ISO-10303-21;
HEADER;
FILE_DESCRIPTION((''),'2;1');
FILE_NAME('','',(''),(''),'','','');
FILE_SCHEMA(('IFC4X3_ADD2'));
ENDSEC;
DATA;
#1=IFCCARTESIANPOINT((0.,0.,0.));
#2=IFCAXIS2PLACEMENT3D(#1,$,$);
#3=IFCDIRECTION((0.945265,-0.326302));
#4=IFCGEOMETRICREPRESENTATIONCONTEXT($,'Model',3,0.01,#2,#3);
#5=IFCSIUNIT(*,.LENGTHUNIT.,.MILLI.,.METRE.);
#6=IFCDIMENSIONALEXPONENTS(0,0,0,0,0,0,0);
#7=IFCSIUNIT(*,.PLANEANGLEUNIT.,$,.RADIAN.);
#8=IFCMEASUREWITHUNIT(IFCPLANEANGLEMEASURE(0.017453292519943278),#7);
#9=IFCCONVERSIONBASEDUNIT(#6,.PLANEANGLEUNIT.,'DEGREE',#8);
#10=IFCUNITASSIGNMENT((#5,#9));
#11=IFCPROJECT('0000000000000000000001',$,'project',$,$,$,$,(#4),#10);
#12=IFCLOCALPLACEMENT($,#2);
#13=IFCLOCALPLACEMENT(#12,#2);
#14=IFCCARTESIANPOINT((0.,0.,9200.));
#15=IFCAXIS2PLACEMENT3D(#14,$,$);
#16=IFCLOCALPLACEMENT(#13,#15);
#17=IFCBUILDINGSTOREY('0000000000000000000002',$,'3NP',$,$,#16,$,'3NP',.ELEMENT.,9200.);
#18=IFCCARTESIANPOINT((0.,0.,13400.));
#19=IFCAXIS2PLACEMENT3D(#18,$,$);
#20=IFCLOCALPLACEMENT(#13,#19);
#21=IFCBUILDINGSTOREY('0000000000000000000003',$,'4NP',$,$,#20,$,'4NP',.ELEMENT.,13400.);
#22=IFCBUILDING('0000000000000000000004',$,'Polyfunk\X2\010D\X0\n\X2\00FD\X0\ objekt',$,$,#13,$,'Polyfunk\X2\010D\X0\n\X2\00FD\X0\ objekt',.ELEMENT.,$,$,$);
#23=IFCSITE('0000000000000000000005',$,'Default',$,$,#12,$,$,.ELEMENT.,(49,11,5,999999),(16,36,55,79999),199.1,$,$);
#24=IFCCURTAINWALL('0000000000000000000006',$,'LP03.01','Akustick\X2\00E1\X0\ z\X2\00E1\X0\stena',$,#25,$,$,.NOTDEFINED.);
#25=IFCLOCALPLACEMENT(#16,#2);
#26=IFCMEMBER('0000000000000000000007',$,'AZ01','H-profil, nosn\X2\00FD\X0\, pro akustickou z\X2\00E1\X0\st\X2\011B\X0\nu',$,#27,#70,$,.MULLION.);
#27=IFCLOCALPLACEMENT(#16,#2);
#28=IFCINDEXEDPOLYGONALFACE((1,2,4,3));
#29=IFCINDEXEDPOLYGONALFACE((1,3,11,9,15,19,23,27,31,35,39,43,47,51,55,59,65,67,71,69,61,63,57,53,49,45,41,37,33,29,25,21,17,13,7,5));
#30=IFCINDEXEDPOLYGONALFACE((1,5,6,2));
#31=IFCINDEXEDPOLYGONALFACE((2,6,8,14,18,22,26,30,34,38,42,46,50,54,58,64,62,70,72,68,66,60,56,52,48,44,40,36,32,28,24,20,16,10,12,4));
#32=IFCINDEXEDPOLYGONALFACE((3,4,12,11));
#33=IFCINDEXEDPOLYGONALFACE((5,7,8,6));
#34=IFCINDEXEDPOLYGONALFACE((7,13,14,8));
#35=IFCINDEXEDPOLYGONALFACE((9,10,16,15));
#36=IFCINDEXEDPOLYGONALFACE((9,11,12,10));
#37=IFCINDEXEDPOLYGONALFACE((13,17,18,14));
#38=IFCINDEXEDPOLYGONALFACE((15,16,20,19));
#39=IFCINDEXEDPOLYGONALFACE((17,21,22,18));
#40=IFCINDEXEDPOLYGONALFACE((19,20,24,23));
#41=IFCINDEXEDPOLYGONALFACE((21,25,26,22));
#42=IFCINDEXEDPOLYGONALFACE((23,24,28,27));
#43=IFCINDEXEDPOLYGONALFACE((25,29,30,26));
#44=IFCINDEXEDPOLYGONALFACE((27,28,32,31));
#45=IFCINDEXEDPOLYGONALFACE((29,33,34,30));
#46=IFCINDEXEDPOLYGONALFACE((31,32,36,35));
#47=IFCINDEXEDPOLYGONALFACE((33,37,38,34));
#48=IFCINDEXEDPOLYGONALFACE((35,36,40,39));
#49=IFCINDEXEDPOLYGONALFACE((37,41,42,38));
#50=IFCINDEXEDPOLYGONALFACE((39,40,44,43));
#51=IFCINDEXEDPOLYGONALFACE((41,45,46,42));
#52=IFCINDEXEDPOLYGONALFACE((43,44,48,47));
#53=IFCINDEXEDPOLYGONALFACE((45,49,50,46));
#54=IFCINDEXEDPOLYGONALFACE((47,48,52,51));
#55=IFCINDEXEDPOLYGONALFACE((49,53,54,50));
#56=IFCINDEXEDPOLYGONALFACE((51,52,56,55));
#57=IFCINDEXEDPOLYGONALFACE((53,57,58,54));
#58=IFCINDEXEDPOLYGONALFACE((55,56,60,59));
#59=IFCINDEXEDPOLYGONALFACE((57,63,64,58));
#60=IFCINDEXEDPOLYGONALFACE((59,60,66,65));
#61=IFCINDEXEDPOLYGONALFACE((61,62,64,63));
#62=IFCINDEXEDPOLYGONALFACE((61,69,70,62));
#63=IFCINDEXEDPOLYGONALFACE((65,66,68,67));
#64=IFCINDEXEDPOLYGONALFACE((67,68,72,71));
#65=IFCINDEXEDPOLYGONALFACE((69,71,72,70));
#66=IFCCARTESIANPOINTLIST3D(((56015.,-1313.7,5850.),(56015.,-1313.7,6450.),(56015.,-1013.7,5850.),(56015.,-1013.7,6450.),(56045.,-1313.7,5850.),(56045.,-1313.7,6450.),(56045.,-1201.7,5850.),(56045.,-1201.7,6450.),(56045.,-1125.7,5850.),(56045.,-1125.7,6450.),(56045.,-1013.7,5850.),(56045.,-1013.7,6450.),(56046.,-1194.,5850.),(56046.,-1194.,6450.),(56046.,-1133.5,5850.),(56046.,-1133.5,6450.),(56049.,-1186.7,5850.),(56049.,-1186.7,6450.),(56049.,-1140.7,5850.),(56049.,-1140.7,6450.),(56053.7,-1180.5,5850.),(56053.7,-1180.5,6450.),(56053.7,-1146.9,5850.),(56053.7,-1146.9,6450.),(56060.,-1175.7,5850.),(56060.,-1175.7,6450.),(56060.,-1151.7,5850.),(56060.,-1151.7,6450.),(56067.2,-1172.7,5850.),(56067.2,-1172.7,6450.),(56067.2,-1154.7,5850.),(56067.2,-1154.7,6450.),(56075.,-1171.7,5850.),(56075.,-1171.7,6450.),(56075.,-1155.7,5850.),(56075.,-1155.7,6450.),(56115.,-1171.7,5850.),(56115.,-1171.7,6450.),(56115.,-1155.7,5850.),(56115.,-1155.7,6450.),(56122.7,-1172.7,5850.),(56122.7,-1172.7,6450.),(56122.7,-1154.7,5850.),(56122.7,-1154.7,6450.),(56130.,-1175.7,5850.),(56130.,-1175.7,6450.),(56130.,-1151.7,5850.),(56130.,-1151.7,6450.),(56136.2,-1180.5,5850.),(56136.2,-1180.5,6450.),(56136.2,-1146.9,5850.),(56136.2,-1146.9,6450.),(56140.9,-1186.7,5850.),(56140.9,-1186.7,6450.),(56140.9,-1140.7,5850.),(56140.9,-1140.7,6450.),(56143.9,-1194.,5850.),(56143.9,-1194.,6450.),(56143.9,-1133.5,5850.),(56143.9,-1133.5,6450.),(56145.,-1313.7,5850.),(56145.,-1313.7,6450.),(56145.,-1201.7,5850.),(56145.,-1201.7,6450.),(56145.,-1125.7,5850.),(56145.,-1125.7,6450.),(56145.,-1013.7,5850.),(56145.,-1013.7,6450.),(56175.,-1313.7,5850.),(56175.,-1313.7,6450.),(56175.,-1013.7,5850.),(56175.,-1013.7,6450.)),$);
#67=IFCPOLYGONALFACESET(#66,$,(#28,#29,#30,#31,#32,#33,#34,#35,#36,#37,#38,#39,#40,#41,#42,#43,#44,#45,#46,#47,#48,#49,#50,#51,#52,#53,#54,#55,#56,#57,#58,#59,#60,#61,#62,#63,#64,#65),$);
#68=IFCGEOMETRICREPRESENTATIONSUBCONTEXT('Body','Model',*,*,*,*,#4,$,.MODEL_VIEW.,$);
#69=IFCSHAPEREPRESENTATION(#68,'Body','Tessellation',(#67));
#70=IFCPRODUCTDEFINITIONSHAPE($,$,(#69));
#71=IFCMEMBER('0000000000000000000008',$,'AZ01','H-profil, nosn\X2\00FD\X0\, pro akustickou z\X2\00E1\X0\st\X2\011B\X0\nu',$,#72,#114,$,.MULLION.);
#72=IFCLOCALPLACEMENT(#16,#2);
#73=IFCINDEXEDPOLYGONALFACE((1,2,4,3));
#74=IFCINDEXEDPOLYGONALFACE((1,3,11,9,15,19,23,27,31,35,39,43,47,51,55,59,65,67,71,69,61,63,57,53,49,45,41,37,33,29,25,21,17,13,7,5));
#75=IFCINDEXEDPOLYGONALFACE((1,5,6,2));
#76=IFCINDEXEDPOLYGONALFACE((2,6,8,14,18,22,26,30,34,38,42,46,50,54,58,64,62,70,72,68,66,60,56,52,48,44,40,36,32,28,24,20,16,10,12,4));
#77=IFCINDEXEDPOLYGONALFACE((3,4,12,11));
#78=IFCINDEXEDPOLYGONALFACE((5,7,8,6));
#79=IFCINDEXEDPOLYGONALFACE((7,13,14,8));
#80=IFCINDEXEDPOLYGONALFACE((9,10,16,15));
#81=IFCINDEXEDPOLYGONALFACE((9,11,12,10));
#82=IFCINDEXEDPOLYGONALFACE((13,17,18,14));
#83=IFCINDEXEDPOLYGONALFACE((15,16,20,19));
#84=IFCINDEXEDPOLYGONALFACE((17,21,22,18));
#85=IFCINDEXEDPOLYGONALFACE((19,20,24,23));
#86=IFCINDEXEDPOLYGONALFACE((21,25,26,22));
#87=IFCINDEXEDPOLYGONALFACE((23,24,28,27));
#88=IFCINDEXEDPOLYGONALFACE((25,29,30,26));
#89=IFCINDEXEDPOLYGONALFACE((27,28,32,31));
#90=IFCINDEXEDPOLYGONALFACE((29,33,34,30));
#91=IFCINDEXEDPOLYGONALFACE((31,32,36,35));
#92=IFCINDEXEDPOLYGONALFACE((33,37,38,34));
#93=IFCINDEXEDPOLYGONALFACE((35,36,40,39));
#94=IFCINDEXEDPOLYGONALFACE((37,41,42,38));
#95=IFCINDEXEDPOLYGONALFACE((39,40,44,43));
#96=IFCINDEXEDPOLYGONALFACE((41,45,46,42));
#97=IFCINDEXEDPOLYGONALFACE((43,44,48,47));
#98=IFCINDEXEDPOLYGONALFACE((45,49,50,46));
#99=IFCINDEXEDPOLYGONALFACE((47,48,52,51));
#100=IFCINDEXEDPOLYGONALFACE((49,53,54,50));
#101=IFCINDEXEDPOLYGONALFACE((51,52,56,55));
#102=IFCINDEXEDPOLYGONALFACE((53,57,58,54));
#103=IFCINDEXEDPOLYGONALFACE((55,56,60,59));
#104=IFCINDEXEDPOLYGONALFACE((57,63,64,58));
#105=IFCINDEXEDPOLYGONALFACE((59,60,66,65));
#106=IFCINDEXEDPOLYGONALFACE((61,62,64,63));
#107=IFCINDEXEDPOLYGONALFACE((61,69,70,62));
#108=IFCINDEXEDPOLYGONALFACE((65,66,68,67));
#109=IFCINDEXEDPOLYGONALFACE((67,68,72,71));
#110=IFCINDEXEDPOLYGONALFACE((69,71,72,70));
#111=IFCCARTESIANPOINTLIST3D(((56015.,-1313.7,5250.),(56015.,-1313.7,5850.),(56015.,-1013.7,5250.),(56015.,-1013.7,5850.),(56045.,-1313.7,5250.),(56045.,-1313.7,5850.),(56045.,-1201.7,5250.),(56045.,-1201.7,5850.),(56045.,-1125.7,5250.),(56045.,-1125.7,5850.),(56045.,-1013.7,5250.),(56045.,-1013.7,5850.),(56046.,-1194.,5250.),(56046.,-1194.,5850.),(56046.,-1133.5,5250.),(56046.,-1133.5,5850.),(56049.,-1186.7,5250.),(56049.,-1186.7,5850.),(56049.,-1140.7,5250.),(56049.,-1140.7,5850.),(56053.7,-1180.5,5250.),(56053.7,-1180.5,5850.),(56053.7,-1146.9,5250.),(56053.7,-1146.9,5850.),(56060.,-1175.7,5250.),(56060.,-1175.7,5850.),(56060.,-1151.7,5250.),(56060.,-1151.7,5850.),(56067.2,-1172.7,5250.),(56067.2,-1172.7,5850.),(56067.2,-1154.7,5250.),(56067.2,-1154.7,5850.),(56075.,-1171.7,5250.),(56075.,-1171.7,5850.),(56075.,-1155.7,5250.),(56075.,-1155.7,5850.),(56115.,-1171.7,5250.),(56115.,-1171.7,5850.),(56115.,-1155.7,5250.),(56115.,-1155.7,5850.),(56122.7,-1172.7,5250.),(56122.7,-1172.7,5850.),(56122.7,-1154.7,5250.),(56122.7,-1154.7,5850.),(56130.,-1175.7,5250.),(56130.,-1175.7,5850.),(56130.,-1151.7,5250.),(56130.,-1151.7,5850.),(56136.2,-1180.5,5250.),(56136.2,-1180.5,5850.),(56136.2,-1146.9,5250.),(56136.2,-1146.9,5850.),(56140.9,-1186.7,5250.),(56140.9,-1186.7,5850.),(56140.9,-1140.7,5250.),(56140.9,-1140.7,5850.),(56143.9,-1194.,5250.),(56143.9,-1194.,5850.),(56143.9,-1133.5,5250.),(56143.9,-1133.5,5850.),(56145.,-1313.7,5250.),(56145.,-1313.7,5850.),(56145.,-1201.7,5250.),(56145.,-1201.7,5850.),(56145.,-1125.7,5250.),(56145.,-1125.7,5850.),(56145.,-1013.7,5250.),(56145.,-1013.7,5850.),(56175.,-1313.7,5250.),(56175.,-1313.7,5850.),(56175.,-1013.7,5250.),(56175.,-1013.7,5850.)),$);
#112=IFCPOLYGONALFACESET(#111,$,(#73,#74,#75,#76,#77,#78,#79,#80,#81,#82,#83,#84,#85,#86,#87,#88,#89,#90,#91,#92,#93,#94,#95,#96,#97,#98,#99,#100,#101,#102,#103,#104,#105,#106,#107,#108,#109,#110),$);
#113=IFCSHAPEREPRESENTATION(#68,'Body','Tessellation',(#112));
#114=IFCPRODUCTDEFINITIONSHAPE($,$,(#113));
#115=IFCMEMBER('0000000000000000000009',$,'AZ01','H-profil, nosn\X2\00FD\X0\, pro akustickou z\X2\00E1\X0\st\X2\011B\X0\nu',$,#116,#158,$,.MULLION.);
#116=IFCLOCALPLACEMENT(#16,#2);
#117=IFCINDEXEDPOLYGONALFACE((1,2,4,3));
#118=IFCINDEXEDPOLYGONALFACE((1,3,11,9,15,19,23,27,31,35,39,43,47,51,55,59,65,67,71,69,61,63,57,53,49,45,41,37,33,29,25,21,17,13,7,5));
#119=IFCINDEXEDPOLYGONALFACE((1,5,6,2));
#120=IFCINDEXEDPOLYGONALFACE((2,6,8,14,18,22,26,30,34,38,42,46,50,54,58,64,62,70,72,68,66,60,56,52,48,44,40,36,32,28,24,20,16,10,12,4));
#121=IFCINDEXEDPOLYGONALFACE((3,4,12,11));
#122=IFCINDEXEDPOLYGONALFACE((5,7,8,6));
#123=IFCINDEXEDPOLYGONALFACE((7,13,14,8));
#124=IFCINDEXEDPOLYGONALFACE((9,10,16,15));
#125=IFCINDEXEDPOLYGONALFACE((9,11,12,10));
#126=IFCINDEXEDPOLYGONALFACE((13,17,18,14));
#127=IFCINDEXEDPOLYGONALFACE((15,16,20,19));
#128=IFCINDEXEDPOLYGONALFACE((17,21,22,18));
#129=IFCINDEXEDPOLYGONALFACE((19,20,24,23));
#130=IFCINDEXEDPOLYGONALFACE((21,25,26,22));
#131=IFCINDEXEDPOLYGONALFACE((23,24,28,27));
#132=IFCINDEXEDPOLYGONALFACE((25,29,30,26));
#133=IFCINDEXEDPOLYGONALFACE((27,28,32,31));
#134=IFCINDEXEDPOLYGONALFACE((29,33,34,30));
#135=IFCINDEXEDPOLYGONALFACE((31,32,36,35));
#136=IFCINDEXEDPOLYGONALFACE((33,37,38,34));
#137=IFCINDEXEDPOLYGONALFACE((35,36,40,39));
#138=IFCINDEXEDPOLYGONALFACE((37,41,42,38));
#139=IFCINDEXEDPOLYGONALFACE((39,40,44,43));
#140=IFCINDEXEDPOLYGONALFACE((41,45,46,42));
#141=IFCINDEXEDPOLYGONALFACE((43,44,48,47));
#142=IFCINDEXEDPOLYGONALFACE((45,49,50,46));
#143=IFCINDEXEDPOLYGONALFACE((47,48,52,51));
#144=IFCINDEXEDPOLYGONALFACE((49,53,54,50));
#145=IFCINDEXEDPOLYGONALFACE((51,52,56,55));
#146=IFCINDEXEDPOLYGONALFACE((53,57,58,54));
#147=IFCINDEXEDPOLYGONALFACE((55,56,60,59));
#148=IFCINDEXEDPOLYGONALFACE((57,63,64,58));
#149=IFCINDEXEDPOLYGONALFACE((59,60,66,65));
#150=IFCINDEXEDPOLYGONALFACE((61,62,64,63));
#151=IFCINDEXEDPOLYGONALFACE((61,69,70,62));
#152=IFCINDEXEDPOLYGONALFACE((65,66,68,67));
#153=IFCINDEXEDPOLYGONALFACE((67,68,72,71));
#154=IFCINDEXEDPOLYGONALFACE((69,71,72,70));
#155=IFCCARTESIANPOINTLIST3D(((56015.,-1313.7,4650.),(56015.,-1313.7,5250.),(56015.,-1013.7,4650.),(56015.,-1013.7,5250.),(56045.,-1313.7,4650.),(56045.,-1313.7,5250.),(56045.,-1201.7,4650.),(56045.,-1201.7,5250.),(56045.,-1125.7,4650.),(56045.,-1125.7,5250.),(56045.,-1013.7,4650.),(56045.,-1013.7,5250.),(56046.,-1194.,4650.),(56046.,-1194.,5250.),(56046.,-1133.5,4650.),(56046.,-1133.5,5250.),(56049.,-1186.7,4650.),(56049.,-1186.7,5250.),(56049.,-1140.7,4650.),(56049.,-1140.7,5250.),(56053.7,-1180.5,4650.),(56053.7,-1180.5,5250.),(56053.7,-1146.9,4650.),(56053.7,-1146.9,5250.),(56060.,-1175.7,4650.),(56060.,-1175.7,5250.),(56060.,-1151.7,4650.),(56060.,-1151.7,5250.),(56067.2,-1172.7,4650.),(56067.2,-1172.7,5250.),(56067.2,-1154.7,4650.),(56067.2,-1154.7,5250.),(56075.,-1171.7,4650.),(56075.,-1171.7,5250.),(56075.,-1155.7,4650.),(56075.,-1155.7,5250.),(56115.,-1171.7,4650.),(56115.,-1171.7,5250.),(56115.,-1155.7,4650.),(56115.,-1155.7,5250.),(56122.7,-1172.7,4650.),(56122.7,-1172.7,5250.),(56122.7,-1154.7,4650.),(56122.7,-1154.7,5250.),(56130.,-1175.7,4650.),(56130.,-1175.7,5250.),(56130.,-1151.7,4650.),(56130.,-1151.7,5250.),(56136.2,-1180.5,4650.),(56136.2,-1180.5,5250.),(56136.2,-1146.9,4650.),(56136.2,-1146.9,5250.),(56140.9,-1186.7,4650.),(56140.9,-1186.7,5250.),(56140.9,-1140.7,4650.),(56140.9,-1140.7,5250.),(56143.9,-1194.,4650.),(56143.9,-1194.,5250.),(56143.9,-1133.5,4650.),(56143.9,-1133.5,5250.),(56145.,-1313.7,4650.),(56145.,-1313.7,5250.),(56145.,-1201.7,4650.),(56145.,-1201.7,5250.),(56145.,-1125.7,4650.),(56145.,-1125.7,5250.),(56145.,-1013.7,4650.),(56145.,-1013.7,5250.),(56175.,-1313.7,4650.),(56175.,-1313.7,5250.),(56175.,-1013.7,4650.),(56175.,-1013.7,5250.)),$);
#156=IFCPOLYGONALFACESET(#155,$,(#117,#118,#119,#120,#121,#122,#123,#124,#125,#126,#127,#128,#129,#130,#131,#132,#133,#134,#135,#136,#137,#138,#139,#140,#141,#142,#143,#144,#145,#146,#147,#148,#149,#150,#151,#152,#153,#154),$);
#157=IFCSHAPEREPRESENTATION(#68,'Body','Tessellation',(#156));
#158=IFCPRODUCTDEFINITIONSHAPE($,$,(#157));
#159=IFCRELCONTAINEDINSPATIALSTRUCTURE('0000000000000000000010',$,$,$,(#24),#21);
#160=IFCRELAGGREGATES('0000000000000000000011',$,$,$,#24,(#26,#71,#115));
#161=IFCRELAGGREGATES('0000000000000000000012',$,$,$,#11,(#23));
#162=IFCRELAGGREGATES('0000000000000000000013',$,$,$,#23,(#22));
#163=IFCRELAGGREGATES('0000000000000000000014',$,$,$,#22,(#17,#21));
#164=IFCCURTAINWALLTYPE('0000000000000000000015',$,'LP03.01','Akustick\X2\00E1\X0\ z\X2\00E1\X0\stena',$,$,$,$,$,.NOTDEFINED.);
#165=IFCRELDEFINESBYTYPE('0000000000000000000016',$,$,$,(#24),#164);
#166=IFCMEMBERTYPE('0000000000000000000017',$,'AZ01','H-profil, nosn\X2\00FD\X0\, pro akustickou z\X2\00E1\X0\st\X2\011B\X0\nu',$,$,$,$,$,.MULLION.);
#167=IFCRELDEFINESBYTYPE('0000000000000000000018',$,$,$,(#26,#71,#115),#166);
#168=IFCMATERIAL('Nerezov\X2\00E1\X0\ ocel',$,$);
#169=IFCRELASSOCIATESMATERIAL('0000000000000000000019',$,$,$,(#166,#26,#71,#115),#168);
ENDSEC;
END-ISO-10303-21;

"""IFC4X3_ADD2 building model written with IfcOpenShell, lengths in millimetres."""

from ifc_helpers import new_model, entity, si_unit, converted_unit, direction, frame, frame_2d, origin, place, context, subcontext, project, spatial, polyline, circle_curve, parameter, trimmed, segment, composite_curve, outline, extrude, source, transform, mapped, material, material_profile, profile_set, profile_usage, type_object, element, aggregate, save


model = new_model("IFC4X3_ADD2")

# Units and contexts
model_context = context("Model", 3, precision=0.01, world=origin(), true_north=direction((0.945265, -0.326302)))
body_context = subcontext(model_context, "Body", "Model", "MODEL_VIEW")
ifc_project = project(units=[si_unit("LENGTHUNIT", "METRE", prefix="MILLI"), converted_unit("PLANEANGLEUNIT", "DEGREE", entity("IfcPlaneAngleMeasure", 0.017453292519943278), si_unit("PLANEANGLEUNIT", "RADIAN"), dimensions=[0, 0, 0, 0, 0, 0, 0])], contexts=[model_context])

# Site, building, storey
site_placement = place(None, origin())
site = spatial("IfcSite", under=ifc_project, at=site_placement, Name="Default", CompositionType="ELEMENT", RefLatitude=(49, 11, 5, 999999), RefLongitude=(16, 36, 55, 79999), RefElevation=199.1)
building_placement = place(site_placement, origin())
building = spatial("IfcBuilding", under=site, at=building_placement, Name="Polyfunkčný objekt", LongName="Polyfunkčný objekt", CompositionType="ELEMENT")
storey_1_placement = place(building_placement, frame((0.0, 0.0, 9200.0)))
storey_1 = spatial("IfcBuildingStorey", under=building, at=storey_1_placement, Name="3NP", LongName="3NP", CompositionType="ELEMENT", Elevation=9200.0)

# Shared definitions
storey_2_placement = place(building_placement, frame((0.0, 0.0, 13400.0)))
storey_2 = spatial("IfcBuildingStorey", under=building, at=storey_2_placement, Name="4NP", LongName="4NP", CompositionType="ELEMENT", Elevation=13400.0)

# Curtain wall, members
curtain_wall_type_1 = type_object("IfcCurtainWallType", Name="LP03.01", Description="Akustická zástena", PredefinedType="NOTDEFINED")
ifc_material_1 = material(Name="Nerezová ocel")
ifc_material_profile_1 = material_profile(ifc_material_1, outline(composite_curve([segment(polyline([(50.0, -150.0), (80.0, -150.0)]), True, "CONTINUOUS"), segment(polyline([(80.0, -150.0), (80.0, 150.0)]), True, "CONTINUOUS"), segment(polyline([(80.0, 150.0), (50.0, 150.0)]), True, "CONTINUOUS"), segment(polyline([(50.0, 150.0), (50.0, 38.0)]), True, "CONTINUOUS"), segment(trimmed(circle_curve(frame_2d((20.0, 38.0), x_axis=(0.0, 1.0)), 30.0), [parameter(180.0)], [parameter(270.0)], True, "PARAMETER"), False, "CONTINUOUS"), segment(polyline([(20.0, 8.0), (-20.0, 8.0)]), True, "CONTINUOUS"), segment(trimmed(circle_curve(frame_2d((-20.0, 38.0), x_axis=(0.0, 1.0)), 30.0), [parameter(90.0)], [parameter(180.0)], True, "PARAMETER"), False, "CONTINUOUS"), segment(polyline([(-50.0, 38.0), (-50.0, 150.0)]), True, "CONTINUOUS"), segment(polyline([(-50.0, 150.0), (-80.0, 150.0)]), True, "CONTINUOUS"), segment(polyline([(-80.0, 150.0), (-80.0, -150.0)]), True, "CONTINUOUS"), segment(polyline([(-80.0, -150.0), (-50.0, -150.0)]), True, "CONTINUOUS"), segment(polyline([(-50.0, -150.0), (-50.0, -38.0)]), True, "CONTINUOUS"), segment(trimmed(circle_curve(frame_2d((-20.0, -38.0), x_axis=(0.0, 1.0)), 30.0), [parameter(0.0)], [parameter(90.0)], True, "PARAMETER"), False, "CONTINUOUS"), segment(polyline([(-20.0, -8.0), (20.0, -8.0)]), True, "CONTINUOUS"), segment(trimmed(circle_curve(frame_2d((20.0, -38.0), x_axis=(0.0, 1.0)), 30.0), [parameter(270.0)], [parameter(0.0)], True, "PARAMETER"), False, "CONTINUOUS"), segment(polyline([(50.0, -38.0), (50.0, -150.0)]), True, "CONTINUOUS")], self_intersect=False)), Name="Profil zástena")
ifc_profile_set_1 = profile_set([ifc_material_profile_1], Name="Profil zástena")
ifc_profile_usage_1 = profile_usage(ifc_profile_set_1)
member_type_1 = type_object("IfcMemberType", Name="AZ01", Description="H-profil, nosný, pro akustickou zástěnu", PredefinedType="MULLION", material=ifc_profile_set_1)
curtain_wall_1_placement = place(storey_2_placement, frame((0.0, 0.0, -13400.0)))
curtain_wall_1 = element("IfcCurtainWall", 1, at=curtain_wall_1_placement, inside=storey_2, type_object=curtain_wall_type_1, Name="LP03.01", Description="Akustická zástena", PredefinedType="NOTDEFINED")
shared_shape_1 = source(origin(), body_context, "Body", "SweptSolid", [
    extrude(outline(composite_curve([segment(polyline([(50.0, -150.0), (80.0, -150.0)]), True, "CONTINUOUS"), segment(polyline([(80.0, -150.0), (80.0, 150.0)]), True, "CONTINUOUS"), segment(polyline([(80.0, 150.0), (50.0, 150.0)]), True, "CONTINUOUS"), segment(polyline([(50.0, 150.0), (50.0, 38.0)]), True, "CONTINUOUS"), segment(trimmed(circle_curve(frame_2d((20.0, 38.0), x_axis=(0.0, 1.0)), 30.0), [parameter(180.0)], [parameter(270.0)], True, "PARAMETER"), False, "CONTINUOUS"), segment(polyline([(20.0, 8.0), (-20.0, 8.0)]), True, "CONTINUOUS"), segment(trimmed(circle_curve(frame_2d((-20.0, 38.0), x_axis=(0.0, 1.0)), 30.0), [parameter(90.0)], [parameter(180.0)], True, "PARAMETER"), False, "CONTINUOUS"), segment(polyline([(-50.0, 38.0), (-50.0, 150.0)]), True, "CONTINUOUS"), segment(polyline([(-50.0, 150.0), (-80.0, 150.0)]), True, "CONTINUOUS"), segment(polyline([(-80.0, 150.0), (-80.0, -150.0)]), True, "CONTINUOUS"), segment(polyline([(-80.0, -150.0), (-50.0, -150.0)]), True, "CONTINUOUS"), segment(polyline([(-50.0, -150.0), (-50.0, -38.0)]), True, "CONTINUOUS"), segment(trimmed(circle_curve(frame_2d((-20.0, -38.0), x_axis=(0.0, 1.0)), 30.0), [parameter(0.0)], [parameter(90.0)], True, "PARAMETER"), False, "CONTINUOUS"), segment(polyline([(-20.0, -8.0), (20.0, -8.0)]), True, "CONTINUOUS"), segment(trimmed(circle_curve(frame_2d((20.0, -38.0), x_axis=(0.0, 1.0)), 30.0), [parameter(270.0)], [parameter(0.0)], True, "PARAMETER"), False, "CONTINUOUS"), segment(polyline([(50.0, -38.0), (50.0, -150.0)]), True, "CONTINUOUS")], self_intersect=False)), frame((-150.0, 0.0, -600.0), z_axis=(0.0, 0.0, 1.0), x_axis=(0.0, 1.0, 0.0)), (0.0, 0.0, 1.0), 600.0),
])
member_1_placement = place(curtain_wall_1_placement, frame((56095.0, -1313.7, 15650.0), z_axis=(0.0, 0.0, 1.0), x_axis=(0.0, -1.0, 0.0)))
member_1 = element("IfcMember", 2, at=member_1_placement, type_object=member_type_1, material=ifc_profile_usage_1, Name="AZ01", Description="H-profil, nosný, pro akustickou zástěnu", PredefinedType="MULLION", context=body_context, shape_type="MappedRepresentation", body=[
    mapped(shared_shape_1, transform((0.0, 0.0, 0.0), scale=1.0)),
])
member_2_placement = place(curtain_wall_1_placement, frame((56095.0, -1313.7, 15050.0), z_axis=(0.0, 0.0, 1.0), x_axis=(0.0, -1.0, 0.0)))
member_2 = element("IfcMember", 3, at=member_2_placement, type_object=member_type_1, material=ifc_profile_usage_1, Name="AZ01", Description="H-profil, nosný, pro akustickou zástěnu", PredefinedType="MULLION", context=body_context, shape_type="MappedRepresentation", body=[
    mapped(shared_shape_1, transform((0.0, 0.0, 0.0), scale=1.0)),
])
member_3_placement = place(curtain_wall_1_placement, frame((56095.0, -1313.7, 14450.0), z_axis=(0.0, 0.0, 1.0), x_axis=(0.0, -1.0, 0.0)))
member_3 = element("IfcMember", 4, at=member_3_placement, type_object=member_type_1, material=ifc_profile_usage_1, Name="AZ01", Description="H-profil, nosný, pro akustickou zástěnu", PredefinedType="MULLION", context=body_context, shape_type="MappedRepresentation", body=[
    mapped(shared_shape_1, transform((0.0, 0.0, 0.0), scale=1.0)),
])

aggregate(curtain_wall_1, [member_1, member_2, member_3])

save(model, "model.ifc")
